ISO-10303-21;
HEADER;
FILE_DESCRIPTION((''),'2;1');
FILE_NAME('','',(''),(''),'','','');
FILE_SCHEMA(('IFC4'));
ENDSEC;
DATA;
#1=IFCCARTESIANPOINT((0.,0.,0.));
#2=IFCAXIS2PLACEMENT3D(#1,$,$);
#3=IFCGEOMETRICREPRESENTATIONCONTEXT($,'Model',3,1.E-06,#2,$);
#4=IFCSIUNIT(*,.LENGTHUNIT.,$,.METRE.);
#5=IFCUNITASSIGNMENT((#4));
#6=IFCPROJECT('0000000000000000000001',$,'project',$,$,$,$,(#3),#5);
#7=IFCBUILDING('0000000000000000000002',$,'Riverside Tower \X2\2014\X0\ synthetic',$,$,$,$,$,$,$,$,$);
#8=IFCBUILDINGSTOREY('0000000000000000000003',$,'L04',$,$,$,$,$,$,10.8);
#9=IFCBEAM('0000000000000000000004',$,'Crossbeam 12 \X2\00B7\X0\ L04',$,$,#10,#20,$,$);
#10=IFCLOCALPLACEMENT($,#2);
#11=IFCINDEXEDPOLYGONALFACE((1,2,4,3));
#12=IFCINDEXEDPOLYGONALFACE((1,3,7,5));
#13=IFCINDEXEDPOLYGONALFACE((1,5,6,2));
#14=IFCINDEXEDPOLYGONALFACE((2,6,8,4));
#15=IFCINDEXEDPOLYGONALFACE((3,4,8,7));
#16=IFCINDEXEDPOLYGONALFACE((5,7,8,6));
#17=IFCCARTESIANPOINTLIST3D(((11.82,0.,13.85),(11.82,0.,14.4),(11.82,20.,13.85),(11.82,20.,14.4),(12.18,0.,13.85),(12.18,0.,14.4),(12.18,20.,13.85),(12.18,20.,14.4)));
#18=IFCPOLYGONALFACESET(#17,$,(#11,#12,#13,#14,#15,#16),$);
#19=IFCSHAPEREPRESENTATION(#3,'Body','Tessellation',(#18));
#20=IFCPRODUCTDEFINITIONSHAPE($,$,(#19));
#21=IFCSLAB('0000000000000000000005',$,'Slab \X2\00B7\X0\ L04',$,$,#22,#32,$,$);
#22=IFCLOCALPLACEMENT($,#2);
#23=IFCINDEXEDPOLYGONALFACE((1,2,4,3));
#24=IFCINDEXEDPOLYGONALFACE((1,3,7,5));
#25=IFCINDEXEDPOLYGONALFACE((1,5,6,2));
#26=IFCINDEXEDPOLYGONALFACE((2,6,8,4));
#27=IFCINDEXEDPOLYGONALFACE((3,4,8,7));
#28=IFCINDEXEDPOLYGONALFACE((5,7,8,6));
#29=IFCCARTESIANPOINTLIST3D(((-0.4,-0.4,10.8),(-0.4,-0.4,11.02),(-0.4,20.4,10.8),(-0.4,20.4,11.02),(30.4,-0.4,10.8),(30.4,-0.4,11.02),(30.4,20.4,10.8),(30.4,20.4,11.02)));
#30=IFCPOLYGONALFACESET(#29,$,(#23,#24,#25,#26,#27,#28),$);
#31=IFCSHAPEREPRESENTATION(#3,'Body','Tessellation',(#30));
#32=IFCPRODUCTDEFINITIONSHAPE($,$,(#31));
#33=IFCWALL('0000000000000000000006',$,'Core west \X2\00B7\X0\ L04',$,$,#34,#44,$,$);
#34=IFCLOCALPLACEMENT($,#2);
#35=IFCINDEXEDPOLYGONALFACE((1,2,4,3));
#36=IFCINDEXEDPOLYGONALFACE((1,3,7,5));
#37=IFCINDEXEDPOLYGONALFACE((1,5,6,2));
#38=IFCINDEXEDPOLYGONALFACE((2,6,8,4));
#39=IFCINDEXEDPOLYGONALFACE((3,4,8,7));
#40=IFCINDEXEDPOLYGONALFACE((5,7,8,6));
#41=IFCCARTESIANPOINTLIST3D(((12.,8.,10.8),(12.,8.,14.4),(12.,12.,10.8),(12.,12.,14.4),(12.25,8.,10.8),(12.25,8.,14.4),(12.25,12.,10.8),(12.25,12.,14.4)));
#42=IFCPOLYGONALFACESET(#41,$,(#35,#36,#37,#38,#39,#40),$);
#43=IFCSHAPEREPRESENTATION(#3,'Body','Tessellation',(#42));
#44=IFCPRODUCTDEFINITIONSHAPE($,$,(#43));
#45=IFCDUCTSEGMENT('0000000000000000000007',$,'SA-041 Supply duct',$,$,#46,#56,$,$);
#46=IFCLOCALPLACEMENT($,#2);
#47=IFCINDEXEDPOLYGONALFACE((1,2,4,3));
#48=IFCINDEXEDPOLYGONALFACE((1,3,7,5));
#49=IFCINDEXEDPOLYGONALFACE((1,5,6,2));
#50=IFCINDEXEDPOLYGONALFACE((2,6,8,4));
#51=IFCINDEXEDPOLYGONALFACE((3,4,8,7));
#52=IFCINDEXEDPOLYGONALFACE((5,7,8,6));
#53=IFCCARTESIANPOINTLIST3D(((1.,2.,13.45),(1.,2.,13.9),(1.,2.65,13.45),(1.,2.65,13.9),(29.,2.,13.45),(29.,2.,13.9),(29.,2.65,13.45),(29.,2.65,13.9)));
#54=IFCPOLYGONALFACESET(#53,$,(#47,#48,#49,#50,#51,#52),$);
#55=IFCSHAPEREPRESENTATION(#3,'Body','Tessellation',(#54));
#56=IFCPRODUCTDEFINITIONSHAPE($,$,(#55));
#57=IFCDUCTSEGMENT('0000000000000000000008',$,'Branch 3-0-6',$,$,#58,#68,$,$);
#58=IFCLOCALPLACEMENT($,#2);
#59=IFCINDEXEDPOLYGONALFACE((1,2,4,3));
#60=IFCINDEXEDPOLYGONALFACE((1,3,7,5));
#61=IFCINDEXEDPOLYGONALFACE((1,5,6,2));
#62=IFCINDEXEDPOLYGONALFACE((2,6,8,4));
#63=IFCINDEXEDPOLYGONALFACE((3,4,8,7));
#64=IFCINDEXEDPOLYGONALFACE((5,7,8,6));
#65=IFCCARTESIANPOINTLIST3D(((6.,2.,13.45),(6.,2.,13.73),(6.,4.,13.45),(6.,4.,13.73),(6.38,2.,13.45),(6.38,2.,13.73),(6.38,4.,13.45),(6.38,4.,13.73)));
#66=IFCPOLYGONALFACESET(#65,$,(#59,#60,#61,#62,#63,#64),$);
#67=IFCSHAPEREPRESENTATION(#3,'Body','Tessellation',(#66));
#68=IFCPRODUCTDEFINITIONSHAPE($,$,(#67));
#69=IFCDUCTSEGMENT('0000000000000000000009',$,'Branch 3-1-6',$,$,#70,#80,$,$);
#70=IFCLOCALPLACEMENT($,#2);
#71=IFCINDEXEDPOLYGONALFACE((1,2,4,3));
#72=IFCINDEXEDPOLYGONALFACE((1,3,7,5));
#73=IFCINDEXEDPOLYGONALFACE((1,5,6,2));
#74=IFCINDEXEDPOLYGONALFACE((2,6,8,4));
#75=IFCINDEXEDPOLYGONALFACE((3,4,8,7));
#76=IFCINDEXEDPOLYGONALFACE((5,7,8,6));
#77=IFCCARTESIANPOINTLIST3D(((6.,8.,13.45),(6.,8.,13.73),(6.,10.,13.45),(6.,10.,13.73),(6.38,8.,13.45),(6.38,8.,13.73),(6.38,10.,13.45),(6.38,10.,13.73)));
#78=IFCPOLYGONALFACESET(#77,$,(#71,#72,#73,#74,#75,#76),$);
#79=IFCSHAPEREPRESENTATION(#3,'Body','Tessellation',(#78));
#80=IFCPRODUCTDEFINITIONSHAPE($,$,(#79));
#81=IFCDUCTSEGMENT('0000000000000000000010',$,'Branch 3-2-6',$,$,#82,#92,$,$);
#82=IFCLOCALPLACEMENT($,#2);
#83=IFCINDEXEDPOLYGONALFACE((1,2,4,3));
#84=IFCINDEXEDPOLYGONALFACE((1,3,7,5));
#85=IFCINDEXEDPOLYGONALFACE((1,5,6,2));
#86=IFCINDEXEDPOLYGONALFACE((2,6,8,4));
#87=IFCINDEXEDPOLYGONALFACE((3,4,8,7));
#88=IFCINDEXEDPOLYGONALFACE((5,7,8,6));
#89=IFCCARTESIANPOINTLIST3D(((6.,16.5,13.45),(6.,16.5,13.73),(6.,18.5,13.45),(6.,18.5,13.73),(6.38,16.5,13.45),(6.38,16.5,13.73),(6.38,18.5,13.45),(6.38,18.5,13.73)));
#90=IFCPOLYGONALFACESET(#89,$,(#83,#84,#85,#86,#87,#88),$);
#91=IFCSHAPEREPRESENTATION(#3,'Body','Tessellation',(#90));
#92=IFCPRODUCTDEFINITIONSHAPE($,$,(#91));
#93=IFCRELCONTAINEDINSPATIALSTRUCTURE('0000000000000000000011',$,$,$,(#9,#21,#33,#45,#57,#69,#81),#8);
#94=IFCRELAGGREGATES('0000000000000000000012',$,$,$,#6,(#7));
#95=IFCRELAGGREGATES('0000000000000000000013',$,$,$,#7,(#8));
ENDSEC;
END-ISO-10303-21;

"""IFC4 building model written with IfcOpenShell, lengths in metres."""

from ifc_helpers import new_model, si_unit, frame, origin, place, context, project, spatial, rectangle, extrude, element, save


model = new_model("IFC4")

# Units and contexts
model_context = context("Model", 3, precision=1e-06, world=origin())
ifc_project = project(units=[si_unit("LENGTHUNIT", "METRE")], contexts=[model_context])

# Building, storey
building = spatial("IfcBuilding", under=ifc_project, Name="Riverside Tower — synthetic")
storey = spatial("IfcBuildingStorey", under=building, Name="L04", Elevation=10.8)

# Beam
for number, where, name in (
    (1, (12.0, 10.0, 13.85), "Crossbeam 12 · L04"),
):
    element("IfcBeam", number, at=place(None, frame(where)), inside=storey, Name=name, context=model_context, shape_type="SweptSolid", body=[
        extrude(rectangle(XDim=0.36, YDim=20.0), origin(), (0.0, 0.0, 1.0), 0.55),
    ])

# Slab
slab_placement = place(None, frame((15.0, 10.0, 10.8)))
element("IfcSlab", 2, at=slab_placement, inside=storey, Name="Slab · L04", context=model_context, shape_type="SweptSolid", body=[
    extrude(rectangle(XDim=30.8, YDim=20.8), origin(), (0.0, 0.0, 1.0), 0.22),
])

# Wall
wall_placement = place(None, frame((12.125, 10.0, 10.8)))
element("IfcWall", 3, at=wall_placement, inside=storey, Name="Core west · L04", context=model_context, shape_type="SweptSolid", body=[
    extrude(rectangle(XDim=0.25, YDim=4.0), origin(), (0.0, 0.0, 1.0), 3.6),
])

# Duct segments
duct_segment_placement = place(None, frame((15.0, 2.325, 13.45)))
element("IfcDuctSegment", 4, at=duct_segment_placement, inside=storey, Name="SA-041 Supply duct", context=model_context, shape_type="SweptSolid", body=[
    extrude(rectangle(XDim=28.0, YDim=0.65), origin(), (0.0, 0.0, 1.0), 0.45),
])
for number, where, name in (
    (5, (6.19, 3.0, 13.45), "Branch 3-0-6"),
    (6, (6.19, 9.0, 13.45), "Branch 3-1-6"),
    (7, (6.19, 17.5, 13.45), "Branch 3-2-6"),
):
    element("IfcDuctSegment", number, at=place(None, frame(where)), inside=storey, Name=name, context=model_context, shape_type="SweptSolid", body=[
        extrude(rectangle(XDim=0.38, YDim=2.0), origin(), (0.0, 0.0, 1.0), 0.28),
    ])

save(model, "model.ifc")
